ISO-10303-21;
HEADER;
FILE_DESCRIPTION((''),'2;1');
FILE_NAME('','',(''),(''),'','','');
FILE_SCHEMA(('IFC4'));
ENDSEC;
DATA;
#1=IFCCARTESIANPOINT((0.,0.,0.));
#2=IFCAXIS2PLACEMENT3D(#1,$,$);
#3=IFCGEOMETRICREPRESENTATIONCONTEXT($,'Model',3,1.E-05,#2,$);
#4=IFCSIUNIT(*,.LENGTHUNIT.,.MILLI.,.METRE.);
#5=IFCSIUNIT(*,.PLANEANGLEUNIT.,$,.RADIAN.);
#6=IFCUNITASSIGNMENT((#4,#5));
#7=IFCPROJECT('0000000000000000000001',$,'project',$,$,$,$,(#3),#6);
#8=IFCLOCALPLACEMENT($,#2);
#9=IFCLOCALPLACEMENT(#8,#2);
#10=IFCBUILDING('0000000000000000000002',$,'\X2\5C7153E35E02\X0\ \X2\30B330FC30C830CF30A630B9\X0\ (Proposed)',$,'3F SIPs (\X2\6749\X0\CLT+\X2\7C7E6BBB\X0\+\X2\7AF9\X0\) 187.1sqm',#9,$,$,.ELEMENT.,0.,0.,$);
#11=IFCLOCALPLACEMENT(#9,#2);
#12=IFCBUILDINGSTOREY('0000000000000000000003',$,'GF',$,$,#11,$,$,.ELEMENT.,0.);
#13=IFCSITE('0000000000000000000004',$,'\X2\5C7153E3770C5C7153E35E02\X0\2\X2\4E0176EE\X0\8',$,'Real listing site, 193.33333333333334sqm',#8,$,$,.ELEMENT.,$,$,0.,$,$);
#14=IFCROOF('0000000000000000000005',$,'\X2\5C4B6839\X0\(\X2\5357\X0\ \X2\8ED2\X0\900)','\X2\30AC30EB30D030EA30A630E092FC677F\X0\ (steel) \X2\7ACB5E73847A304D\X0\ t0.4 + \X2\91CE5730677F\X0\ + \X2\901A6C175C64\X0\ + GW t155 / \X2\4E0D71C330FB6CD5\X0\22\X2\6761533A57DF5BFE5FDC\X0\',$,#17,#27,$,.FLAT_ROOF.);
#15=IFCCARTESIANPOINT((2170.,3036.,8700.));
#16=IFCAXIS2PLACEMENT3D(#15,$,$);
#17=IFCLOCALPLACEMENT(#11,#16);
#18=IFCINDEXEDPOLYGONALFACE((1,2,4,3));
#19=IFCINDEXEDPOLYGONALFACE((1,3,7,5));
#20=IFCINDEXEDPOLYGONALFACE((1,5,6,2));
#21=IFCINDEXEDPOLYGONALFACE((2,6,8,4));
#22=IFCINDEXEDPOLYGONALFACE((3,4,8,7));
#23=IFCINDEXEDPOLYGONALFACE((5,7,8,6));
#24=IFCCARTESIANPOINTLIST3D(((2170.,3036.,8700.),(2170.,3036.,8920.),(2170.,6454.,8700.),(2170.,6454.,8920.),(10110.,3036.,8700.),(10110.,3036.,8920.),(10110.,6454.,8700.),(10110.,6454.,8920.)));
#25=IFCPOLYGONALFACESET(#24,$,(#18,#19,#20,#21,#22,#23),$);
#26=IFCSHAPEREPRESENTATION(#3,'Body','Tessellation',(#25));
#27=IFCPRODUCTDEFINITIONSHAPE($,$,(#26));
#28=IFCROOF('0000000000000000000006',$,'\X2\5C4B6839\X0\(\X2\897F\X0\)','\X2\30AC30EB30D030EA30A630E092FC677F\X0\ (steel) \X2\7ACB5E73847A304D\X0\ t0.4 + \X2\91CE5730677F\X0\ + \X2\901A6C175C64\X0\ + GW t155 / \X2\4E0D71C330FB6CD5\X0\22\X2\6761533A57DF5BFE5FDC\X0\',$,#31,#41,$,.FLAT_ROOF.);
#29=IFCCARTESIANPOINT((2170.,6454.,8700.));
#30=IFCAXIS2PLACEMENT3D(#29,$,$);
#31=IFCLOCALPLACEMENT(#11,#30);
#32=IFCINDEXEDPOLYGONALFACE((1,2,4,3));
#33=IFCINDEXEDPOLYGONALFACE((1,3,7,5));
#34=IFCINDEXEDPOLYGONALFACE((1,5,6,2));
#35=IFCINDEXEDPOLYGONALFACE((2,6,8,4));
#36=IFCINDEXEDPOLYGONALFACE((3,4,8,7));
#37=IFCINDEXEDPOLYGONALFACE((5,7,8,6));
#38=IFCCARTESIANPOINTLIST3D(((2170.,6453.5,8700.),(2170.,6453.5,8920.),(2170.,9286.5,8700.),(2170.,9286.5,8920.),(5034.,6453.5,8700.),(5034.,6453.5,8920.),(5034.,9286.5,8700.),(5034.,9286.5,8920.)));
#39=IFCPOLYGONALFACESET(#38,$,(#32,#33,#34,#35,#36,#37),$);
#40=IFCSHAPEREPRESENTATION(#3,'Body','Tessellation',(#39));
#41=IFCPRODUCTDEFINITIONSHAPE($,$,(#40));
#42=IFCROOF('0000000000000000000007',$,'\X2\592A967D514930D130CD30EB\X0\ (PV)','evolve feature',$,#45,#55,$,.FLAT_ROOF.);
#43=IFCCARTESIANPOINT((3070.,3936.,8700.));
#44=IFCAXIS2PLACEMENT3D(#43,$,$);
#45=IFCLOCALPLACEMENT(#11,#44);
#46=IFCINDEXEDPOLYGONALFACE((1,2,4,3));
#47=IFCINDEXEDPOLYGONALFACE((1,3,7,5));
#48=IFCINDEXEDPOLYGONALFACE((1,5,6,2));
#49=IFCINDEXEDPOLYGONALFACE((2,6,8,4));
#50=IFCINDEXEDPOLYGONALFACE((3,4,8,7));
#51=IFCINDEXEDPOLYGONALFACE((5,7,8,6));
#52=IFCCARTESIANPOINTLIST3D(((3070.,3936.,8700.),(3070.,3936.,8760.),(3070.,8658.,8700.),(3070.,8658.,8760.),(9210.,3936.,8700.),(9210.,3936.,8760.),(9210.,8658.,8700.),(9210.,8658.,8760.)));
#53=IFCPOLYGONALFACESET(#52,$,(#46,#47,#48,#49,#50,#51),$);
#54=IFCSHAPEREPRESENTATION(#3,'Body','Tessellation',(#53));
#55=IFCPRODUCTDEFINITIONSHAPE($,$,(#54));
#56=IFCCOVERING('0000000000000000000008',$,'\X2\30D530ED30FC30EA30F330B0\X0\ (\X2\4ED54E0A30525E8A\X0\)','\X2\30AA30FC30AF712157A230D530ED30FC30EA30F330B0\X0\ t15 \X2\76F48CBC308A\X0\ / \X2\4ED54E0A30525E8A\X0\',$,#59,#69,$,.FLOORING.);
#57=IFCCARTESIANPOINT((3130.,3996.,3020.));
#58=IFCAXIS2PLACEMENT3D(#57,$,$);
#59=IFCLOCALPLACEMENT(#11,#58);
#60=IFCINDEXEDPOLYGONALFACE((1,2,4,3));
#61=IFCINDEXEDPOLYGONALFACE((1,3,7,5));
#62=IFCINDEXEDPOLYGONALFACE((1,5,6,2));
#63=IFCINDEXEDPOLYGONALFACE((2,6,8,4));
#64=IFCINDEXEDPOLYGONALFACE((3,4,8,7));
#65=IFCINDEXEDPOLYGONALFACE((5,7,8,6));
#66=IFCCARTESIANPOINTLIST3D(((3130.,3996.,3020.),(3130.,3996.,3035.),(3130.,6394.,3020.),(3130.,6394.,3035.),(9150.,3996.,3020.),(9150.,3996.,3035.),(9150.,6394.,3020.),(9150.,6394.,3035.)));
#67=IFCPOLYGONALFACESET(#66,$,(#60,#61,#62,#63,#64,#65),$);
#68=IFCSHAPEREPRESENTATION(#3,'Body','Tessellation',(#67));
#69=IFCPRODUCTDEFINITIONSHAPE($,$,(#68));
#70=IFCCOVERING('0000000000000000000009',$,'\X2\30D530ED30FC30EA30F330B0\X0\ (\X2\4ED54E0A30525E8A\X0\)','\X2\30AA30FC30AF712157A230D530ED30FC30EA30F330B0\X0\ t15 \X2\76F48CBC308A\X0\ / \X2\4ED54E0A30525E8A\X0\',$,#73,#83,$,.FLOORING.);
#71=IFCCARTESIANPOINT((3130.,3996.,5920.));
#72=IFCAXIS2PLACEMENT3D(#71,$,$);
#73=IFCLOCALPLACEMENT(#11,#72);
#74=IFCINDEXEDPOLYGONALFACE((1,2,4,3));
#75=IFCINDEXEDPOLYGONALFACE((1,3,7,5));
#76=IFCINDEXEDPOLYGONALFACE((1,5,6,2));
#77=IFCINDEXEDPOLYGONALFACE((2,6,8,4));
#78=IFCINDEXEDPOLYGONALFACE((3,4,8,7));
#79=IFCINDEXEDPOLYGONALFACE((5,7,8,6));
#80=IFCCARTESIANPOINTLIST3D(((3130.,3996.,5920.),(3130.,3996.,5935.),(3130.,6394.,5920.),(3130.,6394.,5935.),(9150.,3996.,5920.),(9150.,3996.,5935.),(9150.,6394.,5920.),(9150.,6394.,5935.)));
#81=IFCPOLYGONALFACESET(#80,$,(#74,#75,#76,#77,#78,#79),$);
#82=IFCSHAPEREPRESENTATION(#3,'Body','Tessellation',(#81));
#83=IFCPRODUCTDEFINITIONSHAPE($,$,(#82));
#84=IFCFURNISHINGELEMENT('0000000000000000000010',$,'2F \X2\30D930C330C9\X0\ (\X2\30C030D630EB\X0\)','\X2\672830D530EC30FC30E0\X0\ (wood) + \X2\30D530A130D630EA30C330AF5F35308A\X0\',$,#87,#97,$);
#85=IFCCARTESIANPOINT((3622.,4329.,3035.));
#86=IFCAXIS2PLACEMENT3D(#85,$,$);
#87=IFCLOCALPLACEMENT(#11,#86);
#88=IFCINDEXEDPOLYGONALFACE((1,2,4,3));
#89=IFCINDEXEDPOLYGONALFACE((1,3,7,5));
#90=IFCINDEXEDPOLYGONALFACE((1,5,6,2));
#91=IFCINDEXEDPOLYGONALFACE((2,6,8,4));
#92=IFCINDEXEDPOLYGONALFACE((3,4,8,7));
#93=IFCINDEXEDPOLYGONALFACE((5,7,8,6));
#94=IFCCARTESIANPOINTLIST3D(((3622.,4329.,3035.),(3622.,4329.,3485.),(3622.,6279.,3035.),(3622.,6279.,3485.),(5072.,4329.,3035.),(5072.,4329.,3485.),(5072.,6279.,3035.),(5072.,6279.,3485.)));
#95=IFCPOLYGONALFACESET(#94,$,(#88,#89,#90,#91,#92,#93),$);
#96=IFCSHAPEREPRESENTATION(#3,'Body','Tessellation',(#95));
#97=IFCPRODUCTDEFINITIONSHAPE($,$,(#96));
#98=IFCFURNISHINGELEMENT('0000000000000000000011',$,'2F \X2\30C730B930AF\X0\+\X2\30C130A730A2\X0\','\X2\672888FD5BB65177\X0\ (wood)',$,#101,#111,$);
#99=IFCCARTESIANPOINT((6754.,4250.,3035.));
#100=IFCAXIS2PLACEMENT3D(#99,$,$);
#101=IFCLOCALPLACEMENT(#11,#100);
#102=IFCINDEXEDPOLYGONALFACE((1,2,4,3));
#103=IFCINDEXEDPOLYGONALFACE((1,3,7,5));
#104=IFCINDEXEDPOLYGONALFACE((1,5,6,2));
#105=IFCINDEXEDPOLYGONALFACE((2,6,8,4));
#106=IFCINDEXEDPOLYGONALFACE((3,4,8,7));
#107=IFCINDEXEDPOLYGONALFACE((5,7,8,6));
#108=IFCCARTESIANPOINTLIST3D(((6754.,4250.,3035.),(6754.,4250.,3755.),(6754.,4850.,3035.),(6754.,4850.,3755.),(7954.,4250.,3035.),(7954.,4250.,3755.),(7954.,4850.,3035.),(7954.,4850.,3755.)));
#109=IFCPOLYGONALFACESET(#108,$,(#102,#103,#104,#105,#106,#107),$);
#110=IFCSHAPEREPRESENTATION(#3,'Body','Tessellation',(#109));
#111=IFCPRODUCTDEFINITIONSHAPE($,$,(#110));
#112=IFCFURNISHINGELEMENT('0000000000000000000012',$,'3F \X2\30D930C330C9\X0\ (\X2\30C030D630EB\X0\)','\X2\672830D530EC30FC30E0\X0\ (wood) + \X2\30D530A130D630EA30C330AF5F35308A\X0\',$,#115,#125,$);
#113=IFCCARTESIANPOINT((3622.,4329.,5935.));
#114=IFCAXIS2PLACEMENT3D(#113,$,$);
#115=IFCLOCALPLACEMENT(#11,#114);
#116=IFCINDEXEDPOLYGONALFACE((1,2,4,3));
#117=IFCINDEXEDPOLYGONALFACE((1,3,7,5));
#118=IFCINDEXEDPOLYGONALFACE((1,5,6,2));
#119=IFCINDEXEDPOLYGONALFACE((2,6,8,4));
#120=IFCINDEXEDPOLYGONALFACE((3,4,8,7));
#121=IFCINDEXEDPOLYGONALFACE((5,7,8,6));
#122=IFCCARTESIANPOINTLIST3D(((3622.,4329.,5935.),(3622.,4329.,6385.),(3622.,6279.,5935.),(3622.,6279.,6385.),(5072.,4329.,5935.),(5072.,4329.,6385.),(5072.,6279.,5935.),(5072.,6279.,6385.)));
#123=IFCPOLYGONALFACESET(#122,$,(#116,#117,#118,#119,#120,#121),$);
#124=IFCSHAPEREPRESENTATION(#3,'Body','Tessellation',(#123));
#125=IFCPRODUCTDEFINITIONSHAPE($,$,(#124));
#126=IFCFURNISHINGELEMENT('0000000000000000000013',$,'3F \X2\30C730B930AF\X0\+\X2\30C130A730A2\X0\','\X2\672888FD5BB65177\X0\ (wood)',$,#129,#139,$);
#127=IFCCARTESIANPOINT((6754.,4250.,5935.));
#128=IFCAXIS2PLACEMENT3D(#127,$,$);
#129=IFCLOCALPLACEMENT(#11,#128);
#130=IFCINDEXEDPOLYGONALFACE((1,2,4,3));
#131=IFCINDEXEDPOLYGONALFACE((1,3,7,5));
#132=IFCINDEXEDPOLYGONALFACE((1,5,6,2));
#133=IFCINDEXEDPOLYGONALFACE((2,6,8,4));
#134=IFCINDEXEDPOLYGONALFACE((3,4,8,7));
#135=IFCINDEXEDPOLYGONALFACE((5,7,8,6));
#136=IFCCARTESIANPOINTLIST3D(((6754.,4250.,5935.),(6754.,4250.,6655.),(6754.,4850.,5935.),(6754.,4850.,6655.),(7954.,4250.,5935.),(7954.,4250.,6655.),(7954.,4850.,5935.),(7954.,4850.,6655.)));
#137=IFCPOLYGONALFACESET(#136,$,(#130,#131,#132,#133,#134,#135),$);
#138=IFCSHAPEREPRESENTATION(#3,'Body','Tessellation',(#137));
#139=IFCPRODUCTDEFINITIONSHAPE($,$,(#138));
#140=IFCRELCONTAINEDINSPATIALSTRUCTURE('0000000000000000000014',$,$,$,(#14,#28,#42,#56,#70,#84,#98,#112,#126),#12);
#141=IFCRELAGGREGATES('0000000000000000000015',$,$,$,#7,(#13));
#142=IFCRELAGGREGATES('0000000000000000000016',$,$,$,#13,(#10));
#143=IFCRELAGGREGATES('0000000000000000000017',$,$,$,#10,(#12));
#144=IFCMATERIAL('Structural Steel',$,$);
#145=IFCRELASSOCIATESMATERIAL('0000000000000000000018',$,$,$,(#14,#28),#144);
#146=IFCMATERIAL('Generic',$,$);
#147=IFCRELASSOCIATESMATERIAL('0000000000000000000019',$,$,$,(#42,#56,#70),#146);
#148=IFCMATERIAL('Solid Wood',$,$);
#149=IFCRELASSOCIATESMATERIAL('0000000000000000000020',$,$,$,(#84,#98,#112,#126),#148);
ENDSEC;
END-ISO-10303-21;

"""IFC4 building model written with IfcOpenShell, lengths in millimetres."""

from ifc_helpers import new_model, si_unit, frame, frame_2d, origin, place, context, project, spatial, rectangle, extrude, material, element, save


model = new_model("IFC4")

# Units and contexts
model_context = context("Model", 3, precision=1e-05, world=origin())
ifc_project = project(units=[si_unit("LENGTHUNIT", "METRE", prefix="MILLI"), si_unit("PLANEANGLEUNIT", "RADIAN")], contexts=[model_context])

# Site, building, storey
site_placement = place(None, origin())
site = spatial("IfcSite", under=ifc_project, at=site_placement, Name="山口県山口市2丁目8", ObjectType="Real listing site, 193.33333333333334sqm", CompositionType="ELEMENT", RefElevation=0.0)
building_placement = place(site_placement, origin())
building = spatial("IfcBuilding", under=site, at=building_placement, Name="山口市 コートハウス (Proposed)", ObjectType="3F SIPs (杉CLT+籾殻+竹) 187.1sqm", CompositionType="ELEMENT", ElevationOfRefHeight=0.0, ElevationOfTerrain=0.0)
storey_placement = place(building_placement, origin())
storey = spatial("IfcBuildingStorey", under=building, at=storey_placement, Name="GF", CompositionType="ELEMENT", Elevation=0.0)

# Shared definitions
ifc_material_1 = material(Name="Solid Wood")

# Roofs
ifc_material_2 = material(Name="Structural Steel")
roof_1_placement = place(storey_placement, frame((2170.0, 3036.0, 8700.0)))
element("IfcRoof", 1, at=roof_1_placement, inside=storey, material=ifc_material_2, Name="屋根(南 軒900)", Description="ガルバリウム鋼板 (steel) 立平葺き t0.4 + 野地板 + 通気層 + GW t155 / 不燃・法22条区域対応", PredefinedType="FLAT_ROOF", context=model_context, shape_type="SweptSolid", body=[
    extrude(rectangle(XDim=7940.0, YDim=3418.0, at=frame_2d((3970.0, 1709.0))), frame((2170.0, 3036.0, 8700.0)), (0.0, 0.0, 1.0), 220.0),
])
roof_2_placement = place(storey_placement, frame((2170.0, 6454.0, 8700.0)))
element("IfcRoof", 2, at=roof_2_placement, inside=storey, material=ifc_material_2, Name="屋根(西)", Description="ガルバリウム鋼板 (steel) 立平葺き t0.4 + 野地板 + 通気層 + GW t155 / 不燃・法22条区域対応", PredefinedType="FLAT_ROOF", context=model_context, shape_type="SweptSolid", body=[
    extrude(rectangle(XDim=2864.0, YDim=2833.0, at=frame_2d((1432.0, 1416.0))), frame((2170.0, 6454.0, 8700.0)), (0.0, 0.0, 1.0), 220.0),
])
ifc_material_3 = material(Name="Generic")
roof_3_placement = place(storey_placement, frame((3070.0, 3936.0, 8700.0)))
element("IfcRoof", 3, at=roof_3_placement, inside=storey, material=ifc_material_3, Name="太陽光パネル (PV)", Description="evolve feature", PredefinedType="FLAT_ROOF", context=model_context, shape_type="SweptSolid", body=[
    extrude(rectangle(XDim=6140.0, YDim=4722.0, at=frame_2d((3070.0, 2361.0))), frame((3070.0, 3936.0, 8700.0)), (0.0, 0.0, 1.0), 60.0),
])

# Coverings
covering_1_placement = place(storey_placement, frame((3130.0, 3996.0, 3020.0)))
element("IfcCovering", 4, at=covering_1_placement, inside=storey, material=ifc_material_3, Name="フローリング (仕上げ床)", Description="オーク無垢フローリング t15 直貼り / 仕上げ床", PredefinedType="FLOORING", context=model_context, shape_type="SweptSolid", body=[
    extrude(rectangle(XDim=6020.0, YDim=2398.0, at=frame_2d((3010.0, 1199.0))), frame((3130.0, 3996.0, 3020.0)), (0.0, 0.0, 1.0), 15.0),
])
covering_2_placement = place(storey_placement, frame((3130.0, 3996.0, 5920.0)))
element("IfcCovering", 5, at=covering_2_placement, inside=storey, material=ifc_material_3, Name="フローリング (仕上げ床)", Description="オーク無垢フローリング t15 直貼り / 仕上げ床", PredefinedType="FLOORING", context=model_context, shape_type="SweptSolid", body=[
    extrude(rectangle(XDim=6020.0, YDim=2398.0, at=frame_2d((3010.0, 1199.0))), frame((3130.0, 3996.0, 5920.0)), (0.0, 0.0, 1.0), 15.0),
])

# Furnishing elements
furnishing_1_placement = place(storey_placement, frame((3622.0, 4329.0, 3035.0)))
element("IfcFurnishingElement", 6, at=furnishing_1_placement, inside=storey, material=ifc_material_1, Name="2F ベッド (ダブル)", Description="木フレーム (wood) + ファブリック張り", context=model_context, shape_type="SweptSolid", body=[
    extrude(rectangle(XDim=1450.0, YDim=1950.0, at=frame_2d((725.0, 975.0))), frame((3622.0, 4329.0, 3035.0)), (0.0, 0.0, 1.0), 450.0),
])
furnishing_2_placement = place(storey_placement, frame((6754.0, 4250.0, 3035.0)))
element("IfcFurnishingElement", 7, at=furnishing_2_placement, inside=storey, material=ifc_material_1, Name="2F デスク+チェア", Description="木製家具 (wood)", context=model_context, shape_type="SweptSolid", body=[
    extrude(rectangle(XDim=1200.0, YDim=600.0, at=frame_2d((600.0, 300.0))), frame((6754.0, 4250.0, 3035.0)), (0.0, 0.0, 1.0), 720.0),
])
furnishing_3_placement = place(storey_placement, frame((3622.0, 4329.0, 5935.0)))
element("IfcFurnishingElement", 8, at=furnishing_3_placement, inside=storey, material=ifc_material_1, Name="3F ベッド (ダブル)", Description="木フレーム (wood) + ファブリック張り", context=model_context, shape_type="SweptSolid", body=[
    extrude(rectangle(XDim=1450.0, YDim=1950.0, at=frame_2d((725.0, 975.0))), frame((3622.0, 4329.0, 5935.0)), (0.0, 0.0, 1.0), 450.0),
])
furnishing_4_placement = place(storey_placement, frame((6754.0, 4250.0, 5935.0)))
element("IfcFurnishingElement", 9, at=furnishing_4_placement, inside=storey, material=ifc_material_1, Name="3F デスク+チェア", Description="木製家具 (wood)", context=model_context, shape_type="SweptSolid", body=[
    extrude(rectangle(XDim=1200.0, YDim=600.0, at=frame_2d((600.0, 300.0))), frame((6754.0, 4250.0, 5935.0)), (0.0, 0.0, 1.0), 720.0),
])

save(model, "model.ifc")
